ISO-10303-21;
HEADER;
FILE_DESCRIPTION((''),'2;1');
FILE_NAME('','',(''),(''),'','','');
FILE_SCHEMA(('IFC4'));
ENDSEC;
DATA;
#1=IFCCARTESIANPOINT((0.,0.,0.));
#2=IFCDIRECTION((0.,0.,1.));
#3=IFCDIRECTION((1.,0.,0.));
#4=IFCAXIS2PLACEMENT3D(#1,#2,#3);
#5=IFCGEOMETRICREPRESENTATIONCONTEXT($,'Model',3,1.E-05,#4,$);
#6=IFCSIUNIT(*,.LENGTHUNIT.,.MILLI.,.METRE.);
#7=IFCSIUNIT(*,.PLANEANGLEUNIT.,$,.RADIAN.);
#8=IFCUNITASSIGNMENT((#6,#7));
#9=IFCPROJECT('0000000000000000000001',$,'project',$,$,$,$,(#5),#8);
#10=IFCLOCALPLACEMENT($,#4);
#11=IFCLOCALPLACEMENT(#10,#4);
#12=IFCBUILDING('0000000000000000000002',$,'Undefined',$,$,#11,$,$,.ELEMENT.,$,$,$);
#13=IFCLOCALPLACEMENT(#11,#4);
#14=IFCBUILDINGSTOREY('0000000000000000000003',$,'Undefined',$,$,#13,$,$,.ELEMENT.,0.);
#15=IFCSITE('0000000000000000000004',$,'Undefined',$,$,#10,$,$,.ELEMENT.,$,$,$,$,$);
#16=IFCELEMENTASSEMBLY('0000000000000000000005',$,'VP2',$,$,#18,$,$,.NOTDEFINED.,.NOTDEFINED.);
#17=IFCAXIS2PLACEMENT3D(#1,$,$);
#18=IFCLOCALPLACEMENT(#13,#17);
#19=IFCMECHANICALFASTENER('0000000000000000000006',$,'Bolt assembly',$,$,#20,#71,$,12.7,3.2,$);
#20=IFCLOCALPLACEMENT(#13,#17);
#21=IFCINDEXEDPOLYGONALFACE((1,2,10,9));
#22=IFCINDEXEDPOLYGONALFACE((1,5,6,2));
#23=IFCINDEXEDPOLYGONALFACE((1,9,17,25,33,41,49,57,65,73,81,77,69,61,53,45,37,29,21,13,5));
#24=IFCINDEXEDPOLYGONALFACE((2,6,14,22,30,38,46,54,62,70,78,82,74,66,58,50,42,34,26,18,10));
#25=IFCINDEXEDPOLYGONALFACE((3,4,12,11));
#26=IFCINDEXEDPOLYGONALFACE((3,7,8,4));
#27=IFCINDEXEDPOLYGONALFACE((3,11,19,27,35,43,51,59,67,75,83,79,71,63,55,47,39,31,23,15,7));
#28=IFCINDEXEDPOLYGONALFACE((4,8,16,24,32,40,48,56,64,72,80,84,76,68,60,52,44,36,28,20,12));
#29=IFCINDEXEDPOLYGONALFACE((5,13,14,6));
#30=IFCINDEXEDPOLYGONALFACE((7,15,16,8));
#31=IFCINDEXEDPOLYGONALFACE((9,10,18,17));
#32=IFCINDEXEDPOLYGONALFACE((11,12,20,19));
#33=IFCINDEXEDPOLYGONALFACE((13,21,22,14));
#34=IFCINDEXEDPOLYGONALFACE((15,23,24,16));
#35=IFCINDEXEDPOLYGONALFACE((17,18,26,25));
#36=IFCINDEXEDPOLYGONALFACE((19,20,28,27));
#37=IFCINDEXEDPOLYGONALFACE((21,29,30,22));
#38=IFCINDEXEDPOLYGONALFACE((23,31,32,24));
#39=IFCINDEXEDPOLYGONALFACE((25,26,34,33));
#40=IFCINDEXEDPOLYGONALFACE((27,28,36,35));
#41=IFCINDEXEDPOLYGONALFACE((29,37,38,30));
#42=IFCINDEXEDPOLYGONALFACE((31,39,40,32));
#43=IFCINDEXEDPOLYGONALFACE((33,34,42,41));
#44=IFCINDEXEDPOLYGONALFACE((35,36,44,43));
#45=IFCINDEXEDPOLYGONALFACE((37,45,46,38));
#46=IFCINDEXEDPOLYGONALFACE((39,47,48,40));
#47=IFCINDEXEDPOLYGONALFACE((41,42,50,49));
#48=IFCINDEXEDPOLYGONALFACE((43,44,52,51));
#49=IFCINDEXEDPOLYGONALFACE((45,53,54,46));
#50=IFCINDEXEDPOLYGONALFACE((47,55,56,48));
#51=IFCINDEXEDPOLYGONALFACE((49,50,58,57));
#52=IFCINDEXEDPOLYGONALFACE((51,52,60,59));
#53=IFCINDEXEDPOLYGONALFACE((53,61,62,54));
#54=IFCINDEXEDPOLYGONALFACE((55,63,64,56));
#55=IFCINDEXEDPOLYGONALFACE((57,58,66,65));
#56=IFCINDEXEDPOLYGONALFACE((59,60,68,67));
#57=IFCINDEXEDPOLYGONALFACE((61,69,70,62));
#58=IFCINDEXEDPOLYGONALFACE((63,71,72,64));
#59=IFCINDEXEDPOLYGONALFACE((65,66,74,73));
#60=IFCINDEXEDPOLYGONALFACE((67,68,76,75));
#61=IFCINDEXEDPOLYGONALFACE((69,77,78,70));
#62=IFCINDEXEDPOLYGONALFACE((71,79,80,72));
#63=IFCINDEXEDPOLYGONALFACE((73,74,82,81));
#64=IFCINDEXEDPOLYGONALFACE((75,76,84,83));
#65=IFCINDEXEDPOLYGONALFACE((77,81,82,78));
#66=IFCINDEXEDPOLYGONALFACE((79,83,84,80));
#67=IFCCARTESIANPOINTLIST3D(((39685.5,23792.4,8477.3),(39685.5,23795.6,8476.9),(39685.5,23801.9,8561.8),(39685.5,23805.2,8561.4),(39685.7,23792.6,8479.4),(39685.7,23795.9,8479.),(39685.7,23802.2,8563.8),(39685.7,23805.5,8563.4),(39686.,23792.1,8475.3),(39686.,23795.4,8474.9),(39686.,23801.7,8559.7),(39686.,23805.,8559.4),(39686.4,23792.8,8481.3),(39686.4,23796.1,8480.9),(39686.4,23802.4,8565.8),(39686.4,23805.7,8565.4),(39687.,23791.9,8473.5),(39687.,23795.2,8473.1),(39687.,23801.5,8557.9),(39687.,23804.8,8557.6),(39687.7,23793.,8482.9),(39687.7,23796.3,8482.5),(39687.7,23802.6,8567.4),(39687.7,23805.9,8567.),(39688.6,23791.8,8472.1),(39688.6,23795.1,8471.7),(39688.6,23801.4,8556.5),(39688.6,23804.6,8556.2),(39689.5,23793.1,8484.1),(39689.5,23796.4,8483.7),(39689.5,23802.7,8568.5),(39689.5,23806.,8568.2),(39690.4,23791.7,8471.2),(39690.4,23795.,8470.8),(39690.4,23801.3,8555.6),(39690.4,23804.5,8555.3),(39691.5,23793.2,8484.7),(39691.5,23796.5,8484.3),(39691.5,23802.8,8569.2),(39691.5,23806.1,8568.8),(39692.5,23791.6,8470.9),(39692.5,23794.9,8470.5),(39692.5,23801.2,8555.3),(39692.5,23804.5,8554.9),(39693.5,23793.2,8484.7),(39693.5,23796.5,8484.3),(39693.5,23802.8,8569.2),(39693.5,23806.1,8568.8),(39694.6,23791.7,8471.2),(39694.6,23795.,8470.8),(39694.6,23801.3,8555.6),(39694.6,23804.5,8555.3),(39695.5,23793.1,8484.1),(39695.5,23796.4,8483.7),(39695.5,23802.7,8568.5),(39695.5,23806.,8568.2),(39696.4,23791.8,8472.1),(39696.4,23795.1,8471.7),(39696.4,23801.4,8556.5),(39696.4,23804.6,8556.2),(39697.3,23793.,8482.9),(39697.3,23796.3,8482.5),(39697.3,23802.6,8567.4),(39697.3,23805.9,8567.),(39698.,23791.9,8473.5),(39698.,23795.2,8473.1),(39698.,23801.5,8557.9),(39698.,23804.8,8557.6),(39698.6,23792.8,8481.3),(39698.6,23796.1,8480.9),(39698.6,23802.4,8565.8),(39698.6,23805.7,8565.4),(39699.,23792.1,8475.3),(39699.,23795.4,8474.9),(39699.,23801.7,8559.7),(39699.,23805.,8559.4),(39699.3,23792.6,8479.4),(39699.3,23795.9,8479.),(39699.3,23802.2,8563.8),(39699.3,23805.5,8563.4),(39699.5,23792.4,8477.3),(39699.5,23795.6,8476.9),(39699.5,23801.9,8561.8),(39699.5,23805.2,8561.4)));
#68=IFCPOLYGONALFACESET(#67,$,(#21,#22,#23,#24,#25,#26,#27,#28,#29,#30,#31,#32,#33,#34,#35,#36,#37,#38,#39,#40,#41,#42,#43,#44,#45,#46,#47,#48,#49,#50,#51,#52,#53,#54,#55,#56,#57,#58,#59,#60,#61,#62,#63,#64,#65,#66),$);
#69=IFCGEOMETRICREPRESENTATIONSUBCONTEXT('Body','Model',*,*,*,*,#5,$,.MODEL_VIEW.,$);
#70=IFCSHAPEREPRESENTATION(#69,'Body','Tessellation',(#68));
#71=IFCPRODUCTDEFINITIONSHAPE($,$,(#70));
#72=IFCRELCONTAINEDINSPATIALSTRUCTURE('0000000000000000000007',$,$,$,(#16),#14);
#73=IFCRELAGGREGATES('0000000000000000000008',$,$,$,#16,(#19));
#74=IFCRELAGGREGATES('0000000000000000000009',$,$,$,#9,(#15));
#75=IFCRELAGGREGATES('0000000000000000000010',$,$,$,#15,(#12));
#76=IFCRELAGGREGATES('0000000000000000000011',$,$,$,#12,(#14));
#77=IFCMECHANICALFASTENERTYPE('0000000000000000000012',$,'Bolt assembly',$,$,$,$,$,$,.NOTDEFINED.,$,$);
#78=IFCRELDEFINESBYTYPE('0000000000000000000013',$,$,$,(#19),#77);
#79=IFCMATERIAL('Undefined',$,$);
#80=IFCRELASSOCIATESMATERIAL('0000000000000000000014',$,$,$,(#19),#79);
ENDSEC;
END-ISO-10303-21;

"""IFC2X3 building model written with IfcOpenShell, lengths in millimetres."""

from ifc_helpers import new_model, si_unit, frame, origin_with_axes, origin_2d_with_axis, place, context, subcontext, project, spatial, circle, extrude, source, transform, mapped, material, type_object, element, aggregate, save


model = new_model("IFC2X3")

# Units and contexts
model_context = context("Model", 3, precision=1e-05, world=origin_with_axes())
body_context = subcontext(model_context, "Body", "Model", "MODEL_VIEW")
ifc_project = project(units=[si_unit("LENGTHUNIT", "METRE", prefix="MILLI"), si_unit("PLANEANGLEUNIT", "RADIAN")], contexts=[model_context])

# Site, building, storey
site_placement = place(None, origin_with_axes())
site = spatial("IfcSite", under=ifc_project, at=site_placement, Name="Undefined", CompositionType="ELEMENT")
building_placement = place(site_placement, origin_with_axes())
building = spatial("IfcBuilding", under=site, at=building_placement, Name="Undefined", CompositionType="ELEMENT")
storey_placement = place(building_placement, origin_with_axes())
storey = spatial("IfcBuildingStorey", under=building, at=storey_placement, Name="Undefined", CompositionType="ELEMENT", Elevation=0.0)

# Element assembly
assembly_1_placement = place(storey_placement, origin_with_axes())
assembly_1 = element("IfcElementAssembly", 1, at=assembly_1_placement, inside=storey, Name="VP2", AssemblyPlace="NOTDEFINED", PredefinedType="NOTDEFINED")

# Shared definitions
ifc_material_1 = material(Name="Undefined")
mechanical_fastener_type = type_object("IfcMechanicalFastenerType", Name="Bolt assembly")

# Mechanical fastener
shared_shape_1 = source(origin_with_axes(), body_context, "Body", "SweptSolid", [
    extrude(circle(Radius=7.0, at=origin_2d_with_axis()), frame((0.0, -3.2, 0.0), z_axis=(0.0, 1.0, 0.0), x_axis=(1.0, 0.0, 0.0)), (0.0, 0.0, 1.0), 3.3),
])
mechanical_fastener_1_placement = place(assembly_1_placement, frame((39692.5, 23805.2, 8561.9), z_axis=(1.0, 0.0, 0.0), x_axis=(0.0, -0.112644, -0.993635)))
mechanical_fastener_1 = element("IfcMechanicalFastener", 2, at=mechanical_fastener_1_placement, type_object=mechanical_fastener_type, material=ifc_material_1, Name="Bolt assembly", NominalDiameter=12.7, NominalLength=3.2, context=body_context, shape_type="MappedRepresentation", body=[
    mapped(shared_shape_1, transform((0.0, 0.0, 0.0))),
    mapped(shared_shape_1, transform((85.0, 0.0, 0.0))),
])
aggregate(assembly_1, [mechanical_fastener_1])

save(model, "model.ifc")
